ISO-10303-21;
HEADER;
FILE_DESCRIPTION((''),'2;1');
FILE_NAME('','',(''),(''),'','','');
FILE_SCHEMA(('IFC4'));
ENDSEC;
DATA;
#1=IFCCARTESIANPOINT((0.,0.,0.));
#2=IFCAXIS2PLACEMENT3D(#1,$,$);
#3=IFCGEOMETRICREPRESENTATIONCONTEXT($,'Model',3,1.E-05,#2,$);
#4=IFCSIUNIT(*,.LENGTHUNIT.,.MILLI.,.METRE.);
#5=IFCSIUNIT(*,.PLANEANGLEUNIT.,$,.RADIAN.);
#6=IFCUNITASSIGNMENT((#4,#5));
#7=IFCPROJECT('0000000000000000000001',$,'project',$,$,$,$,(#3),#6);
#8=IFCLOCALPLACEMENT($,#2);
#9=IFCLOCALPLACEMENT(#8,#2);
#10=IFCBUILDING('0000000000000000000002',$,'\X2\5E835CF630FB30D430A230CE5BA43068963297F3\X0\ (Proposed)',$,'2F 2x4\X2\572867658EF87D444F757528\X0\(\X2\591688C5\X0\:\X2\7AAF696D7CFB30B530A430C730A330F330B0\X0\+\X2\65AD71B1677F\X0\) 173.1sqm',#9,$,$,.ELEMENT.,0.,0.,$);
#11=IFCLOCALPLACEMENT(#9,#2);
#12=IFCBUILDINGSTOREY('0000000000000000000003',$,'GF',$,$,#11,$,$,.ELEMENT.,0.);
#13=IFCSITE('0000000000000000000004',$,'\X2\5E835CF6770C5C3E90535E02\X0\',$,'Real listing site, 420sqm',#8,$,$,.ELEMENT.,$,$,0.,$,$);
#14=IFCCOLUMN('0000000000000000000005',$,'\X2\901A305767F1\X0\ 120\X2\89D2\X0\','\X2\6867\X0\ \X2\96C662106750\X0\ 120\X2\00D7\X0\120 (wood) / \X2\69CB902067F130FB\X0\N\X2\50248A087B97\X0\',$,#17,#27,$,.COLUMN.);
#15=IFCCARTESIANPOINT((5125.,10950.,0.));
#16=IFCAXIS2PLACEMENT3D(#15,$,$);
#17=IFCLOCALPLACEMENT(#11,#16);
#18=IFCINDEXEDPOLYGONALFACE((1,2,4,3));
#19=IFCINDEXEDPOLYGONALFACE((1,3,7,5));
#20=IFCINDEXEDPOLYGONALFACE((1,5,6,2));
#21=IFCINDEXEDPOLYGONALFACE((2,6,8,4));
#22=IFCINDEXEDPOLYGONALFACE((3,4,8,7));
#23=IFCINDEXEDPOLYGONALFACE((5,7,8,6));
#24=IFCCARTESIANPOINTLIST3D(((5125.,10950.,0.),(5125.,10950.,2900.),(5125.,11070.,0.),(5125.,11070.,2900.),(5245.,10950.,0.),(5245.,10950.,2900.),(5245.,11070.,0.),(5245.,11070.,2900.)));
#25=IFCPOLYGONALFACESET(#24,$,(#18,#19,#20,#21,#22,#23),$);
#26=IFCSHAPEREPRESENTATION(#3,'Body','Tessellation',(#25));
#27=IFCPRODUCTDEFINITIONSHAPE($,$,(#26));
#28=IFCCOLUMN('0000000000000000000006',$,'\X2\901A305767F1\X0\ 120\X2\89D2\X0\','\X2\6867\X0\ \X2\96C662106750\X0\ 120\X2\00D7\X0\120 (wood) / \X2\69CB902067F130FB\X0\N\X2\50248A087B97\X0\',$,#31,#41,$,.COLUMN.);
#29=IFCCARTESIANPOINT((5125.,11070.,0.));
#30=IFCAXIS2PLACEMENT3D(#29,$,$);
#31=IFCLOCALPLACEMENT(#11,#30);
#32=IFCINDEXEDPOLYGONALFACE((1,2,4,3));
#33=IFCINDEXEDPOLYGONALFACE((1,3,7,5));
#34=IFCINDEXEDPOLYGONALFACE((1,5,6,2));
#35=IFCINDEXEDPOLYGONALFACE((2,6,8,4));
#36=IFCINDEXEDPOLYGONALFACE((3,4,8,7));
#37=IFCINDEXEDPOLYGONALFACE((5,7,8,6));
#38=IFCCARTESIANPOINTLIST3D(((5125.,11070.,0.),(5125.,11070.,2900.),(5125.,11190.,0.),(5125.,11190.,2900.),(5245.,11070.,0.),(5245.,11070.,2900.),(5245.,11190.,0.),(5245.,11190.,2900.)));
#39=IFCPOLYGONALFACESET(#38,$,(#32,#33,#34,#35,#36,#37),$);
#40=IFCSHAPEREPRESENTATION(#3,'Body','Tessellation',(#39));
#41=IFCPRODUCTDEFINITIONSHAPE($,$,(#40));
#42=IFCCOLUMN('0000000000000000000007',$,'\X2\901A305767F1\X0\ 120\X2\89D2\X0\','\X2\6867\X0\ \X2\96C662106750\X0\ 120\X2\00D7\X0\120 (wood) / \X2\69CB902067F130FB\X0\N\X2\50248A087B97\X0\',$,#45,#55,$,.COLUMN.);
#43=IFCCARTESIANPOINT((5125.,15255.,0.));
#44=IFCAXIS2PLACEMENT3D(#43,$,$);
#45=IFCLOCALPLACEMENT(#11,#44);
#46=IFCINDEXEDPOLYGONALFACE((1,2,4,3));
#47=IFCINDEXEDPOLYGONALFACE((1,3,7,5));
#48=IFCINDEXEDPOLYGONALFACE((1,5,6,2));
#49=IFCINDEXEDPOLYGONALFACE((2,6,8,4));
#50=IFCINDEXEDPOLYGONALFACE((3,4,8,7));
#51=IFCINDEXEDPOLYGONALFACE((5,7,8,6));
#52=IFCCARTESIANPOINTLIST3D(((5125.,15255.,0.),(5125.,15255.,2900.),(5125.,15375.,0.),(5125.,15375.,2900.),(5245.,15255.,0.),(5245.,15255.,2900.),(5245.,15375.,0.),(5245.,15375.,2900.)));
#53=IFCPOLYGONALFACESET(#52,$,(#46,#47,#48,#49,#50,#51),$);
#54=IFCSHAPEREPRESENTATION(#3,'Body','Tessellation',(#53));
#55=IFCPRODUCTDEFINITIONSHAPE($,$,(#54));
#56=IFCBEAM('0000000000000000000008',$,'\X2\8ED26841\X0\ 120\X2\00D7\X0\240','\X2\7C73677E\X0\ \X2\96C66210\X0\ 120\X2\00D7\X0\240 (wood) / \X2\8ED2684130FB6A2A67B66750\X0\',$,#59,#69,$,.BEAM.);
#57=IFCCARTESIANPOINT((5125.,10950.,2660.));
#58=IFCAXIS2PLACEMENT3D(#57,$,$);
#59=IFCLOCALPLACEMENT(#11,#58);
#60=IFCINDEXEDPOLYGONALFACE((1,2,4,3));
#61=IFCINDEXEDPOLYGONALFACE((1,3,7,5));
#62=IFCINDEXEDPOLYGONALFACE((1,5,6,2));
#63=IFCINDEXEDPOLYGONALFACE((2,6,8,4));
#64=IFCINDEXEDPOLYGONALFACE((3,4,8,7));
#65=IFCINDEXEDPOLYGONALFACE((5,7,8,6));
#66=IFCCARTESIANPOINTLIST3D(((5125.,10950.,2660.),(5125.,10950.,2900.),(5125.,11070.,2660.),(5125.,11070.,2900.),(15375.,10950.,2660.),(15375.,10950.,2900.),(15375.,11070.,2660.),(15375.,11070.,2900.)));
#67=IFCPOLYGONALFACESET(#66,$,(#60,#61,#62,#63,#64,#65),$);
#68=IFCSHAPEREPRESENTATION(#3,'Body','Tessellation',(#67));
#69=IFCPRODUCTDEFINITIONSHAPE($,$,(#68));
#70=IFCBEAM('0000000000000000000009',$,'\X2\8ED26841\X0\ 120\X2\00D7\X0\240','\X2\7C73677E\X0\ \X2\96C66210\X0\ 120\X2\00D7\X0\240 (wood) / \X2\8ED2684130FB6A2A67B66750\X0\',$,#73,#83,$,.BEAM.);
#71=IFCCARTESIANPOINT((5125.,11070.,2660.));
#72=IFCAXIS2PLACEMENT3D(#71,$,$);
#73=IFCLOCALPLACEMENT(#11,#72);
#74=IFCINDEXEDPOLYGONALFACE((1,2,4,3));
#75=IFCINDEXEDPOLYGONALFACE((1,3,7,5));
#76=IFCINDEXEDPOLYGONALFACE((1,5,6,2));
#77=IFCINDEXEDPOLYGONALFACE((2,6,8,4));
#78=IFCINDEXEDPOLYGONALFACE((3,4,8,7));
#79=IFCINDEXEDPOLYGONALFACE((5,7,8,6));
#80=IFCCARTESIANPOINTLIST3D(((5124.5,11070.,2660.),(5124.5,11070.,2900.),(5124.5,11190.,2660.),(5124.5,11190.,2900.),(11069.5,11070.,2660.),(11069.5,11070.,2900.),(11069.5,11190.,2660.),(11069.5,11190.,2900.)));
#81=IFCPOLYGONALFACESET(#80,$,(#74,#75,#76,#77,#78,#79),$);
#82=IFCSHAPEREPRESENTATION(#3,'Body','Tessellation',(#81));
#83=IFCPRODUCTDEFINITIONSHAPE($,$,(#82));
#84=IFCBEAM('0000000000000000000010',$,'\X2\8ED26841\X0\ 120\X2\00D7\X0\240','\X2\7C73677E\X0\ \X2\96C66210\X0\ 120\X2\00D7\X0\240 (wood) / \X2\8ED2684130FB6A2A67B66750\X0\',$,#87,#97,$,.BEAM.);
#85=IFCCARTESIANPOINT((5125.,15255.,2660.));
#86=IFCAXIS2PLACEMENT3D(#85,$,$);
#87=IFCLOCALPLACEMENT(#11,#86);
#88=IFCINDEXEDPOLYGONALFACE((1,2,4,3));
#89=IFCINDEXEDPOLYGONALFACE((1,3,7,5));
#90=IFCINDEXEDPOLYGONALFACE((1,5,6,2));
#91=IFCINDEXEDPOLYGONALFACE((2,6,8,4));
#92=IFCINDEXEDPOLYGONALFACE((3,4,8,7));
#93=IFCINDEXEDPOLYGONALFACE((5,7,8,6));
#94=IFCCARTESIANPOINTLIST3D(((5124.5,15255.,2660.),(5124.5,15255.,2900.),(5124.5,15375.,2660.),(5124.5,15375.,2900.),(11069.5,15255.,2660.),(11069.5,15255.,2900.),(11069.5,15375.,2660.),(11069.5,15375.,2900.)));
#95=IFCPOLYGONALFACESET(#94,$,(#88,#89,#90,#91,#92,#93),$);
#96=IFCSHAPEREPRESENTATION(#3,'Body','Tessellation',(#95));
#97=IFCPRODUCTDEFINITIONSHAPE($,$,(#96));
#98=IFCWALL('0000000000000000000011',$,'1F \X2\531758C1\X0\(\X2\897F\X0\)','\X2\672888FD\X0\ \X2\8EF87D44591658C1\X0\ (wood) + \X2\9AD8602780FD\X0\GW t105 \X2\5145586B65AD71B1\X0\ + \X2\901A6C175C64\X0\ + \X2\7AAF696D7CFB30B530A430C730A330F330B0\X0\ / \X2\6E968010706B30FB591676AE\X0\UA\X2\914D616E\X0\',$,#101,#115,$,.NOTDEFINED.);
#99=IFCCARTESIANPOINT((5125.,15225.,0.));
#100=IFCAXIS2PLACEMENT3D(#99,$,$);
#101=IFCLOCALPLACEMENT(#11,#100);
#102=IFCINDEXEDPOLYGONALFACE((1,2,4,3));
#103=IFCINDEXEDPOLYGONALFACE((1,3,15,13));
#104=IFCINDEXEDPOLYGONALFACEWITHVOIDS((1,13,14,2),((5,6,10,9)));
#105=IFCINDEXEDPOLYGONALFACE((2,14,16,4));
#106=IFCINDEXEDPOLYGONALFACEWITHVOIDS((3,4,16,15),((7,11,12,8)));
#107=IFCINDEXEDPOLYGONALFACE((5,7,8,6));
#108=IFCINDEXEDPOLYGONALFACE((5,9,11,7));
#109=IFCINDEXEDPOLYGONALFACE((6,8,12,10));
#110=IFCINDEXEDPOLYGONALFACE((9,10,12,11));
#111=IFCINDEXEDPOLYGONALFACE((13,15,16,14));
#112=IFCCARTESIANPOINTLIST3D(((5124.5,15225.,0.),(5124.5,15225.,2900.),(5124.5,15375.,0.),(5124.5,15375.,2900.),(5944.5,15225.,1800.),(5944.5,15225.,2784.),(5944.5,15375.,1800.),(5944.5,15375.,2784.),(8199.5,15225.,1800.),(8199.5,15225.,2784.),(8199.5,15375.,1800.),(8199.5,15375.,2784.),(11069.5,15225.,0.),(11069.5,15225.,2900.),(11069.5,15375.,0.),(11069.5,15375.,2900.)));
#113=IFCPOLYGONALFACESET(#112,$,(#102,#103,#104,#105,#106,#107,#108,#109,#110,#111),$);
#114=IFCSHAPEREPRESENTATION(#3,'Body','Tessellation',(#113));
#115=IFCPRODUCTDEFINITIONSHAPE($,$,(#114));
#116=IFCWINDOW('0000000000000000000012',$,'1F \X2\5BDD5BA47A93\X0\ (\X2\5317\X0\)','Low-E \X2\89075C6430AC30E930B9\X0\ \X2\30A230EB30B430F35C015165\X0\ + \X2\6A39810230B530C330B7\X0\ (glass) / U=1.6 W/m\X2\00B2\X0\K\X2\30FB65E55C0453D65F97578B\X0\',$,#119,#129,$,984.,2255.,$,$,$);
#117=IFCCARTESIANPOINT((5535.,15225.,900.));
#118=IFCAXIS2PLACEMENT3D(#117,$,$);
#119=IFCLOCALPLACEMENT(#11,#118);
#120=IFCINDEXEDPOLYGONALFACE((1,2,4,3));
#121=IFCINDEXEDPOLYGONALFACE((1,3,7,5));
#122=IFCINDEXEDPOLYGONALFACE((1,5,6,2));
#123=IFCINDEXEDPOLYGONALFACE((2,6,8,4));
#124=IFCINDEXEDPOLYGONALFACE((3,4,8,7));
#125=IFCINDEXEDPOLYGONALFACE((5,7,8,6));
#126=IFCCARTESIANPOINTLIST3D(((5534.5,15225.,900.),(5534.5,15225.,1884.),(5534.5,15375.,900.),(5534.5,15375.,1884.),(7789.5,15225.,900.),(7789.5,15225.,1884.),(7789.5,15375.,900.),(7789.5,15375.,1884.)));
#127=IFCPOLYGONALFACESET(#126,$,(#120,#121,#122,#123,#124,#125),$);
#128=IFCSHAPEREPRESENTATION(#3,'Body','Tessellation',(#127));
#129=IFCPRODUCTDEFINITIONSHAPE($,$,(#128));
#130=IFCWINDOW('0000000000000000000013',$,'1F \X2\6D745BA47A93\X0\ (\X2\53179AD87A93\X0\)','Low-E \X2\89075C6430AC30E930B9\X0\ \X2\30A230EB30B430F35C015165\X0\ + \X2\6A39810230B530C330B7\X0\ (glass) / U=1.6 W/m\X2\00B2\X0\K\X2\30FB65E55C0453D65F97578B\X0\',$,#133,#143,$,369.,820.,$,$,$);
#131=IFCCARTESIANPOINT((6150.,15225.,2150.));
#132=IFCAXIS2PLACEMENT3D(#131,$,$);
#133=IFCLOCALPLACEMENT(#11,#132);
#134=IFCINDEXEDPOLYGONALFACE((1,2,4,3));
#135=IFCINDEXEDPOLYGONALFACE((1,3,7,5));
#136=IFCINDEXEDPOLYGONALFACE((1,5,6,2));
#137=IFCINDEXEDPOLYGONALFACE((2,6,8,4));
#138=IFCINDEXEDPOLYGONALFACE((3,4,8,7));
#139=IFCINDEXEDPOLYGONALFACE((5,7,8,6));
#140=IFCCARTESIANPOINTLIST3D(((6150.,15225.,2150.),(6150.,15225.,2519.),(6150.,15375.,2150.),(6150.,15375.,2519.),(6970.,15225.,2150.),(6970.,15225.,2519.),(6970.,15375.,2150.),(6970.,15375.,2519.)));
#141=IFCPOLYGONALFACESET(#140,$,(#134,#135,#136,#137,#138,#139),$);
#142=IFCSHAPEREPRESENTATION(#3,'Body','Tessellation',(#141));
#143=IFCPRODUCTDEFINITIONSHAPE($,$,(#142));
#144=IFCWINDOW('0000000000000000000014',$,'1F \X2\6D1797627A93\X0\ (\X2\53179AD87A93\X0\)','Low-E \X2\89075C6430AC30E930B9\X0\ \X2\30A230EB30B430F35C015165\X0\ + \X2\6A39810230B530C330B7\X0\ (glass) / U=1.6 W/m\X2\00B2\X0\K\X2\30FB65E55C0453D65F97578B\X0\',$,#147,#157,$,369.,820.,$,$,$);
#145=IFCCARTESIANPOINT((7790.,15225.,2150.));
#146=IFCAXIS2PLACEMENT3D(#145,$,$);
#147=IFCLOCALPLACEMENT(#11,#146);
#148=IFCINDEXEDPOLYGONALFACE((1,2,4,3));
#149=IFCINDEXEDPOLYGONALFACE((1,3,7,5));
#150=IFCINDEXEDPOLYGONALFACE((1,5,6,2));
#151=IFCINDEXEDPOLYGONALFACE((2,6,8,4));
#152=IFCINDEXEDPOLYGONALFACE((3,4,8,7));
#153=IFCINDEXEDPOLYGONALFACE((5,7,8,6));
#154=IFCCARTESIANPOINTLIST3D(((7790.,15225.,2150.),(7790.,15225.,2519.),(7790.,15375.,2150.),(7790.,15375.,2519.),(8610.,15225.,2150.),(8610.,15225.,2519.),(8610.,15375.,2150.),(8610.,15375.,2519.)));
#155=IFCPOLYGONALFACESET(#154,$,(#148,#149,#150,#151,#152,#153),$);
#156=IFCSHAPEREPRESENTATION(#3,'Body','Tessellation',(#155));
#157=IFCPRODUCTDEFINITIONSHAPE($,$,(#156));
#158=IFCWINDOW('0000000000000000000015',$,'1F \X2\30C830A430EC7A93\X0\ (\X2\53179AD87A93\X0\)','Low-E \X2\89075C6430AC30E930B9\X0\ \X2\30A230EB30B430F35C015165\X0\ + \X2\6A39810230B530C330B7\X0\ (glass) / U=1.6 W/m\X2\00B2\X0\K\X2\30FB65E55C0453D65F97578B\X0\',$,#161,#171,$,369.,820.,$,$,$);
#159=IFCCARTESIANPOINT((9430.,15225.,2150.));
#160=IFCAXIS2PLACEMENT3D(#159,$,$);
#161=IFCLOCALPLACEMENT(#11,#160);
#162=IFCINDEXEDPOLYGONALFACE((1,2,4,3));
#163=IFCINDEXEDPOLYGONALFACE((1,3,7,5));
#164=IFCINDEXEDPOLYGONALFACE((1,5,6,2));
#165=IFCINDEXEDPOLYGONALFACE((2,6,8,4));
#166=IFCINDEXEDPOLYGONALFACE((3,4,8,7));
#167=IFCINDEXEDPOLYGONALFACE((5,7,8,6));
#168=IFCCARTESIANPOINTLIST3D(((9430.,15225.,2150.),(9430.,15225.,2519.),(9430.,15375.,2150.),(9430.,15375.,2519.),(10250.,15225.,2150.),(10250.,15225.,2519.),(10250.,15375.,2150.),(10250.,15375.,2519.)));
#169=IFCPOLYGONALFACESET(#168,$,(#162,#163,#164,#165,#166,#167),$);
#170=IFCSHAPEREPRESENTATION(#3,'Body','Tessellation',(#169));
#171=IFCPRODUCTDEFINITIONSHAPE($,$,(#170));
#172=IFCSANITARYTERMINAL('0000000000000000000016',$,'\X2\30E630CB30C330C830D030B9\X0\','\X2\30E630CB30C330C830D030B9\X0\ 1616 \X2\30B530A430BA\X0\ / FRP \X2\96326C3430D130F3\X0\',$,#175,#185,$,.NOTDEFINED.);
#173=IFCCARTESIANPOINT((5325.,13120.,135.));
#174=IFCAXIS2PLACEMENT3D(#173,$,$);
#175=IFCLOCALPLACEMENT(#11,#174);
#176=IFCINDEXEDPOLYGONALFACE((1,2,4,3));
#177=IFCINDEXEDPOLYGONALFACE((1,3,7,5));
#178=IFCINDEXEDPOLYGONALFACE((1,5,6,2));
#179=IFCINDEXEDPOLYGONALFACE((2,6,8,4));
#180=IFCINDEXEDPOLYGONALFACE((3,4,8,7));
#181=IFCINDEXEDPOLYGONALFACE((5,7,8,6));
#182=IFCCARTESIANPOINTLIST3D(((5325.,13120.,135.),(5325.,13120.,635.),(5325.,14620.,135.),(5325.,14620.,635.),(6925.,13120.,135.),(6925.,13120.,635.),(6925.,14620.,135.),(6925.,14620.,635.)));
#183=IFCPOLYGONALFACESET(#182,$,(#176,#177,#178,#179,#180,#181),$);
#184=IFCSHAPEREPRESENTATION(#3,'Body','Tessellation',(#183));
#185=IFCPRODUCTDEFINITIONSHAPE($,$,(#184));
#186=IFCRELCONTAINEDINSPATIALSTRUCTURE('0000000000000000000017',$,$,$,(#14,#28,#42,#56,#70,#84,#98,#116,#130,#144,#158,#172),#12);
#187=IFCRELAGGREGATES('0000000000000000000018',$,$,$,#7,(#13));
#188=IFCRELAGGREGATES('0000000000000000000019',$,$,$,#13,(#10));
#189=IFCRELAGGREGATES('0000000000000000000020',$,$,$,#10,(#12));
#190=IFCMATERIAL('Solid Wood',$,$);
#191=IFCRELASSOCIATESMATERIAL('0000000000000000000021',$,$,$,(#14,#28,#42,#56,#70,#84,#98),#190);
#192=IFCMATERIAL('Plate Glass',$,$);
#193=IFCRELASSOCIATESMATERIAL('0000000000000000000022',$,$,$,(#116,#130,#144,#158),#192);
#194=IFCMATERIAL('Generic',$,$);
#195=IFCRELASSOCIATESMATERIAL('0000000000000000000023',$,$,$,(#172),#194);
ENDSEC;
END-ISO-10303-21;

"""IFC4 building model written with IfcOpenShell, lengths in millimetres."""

from ifc_helpers import new_model, si_unit, frame, frame_2d, origin, place, context, project, spatial, rectangle, extrude, material, element, fill, save


model = new_model("IFC4")

# Units and contexts
model_context = context("Model", 3, precision=1e-05, world=origin())
ifc_project = project(units=[si_unit("LENGTHUNIT", "METRE", prefix="MILLI"), si_unit("PLANEANGLEUNIT", "RADIAN")], contexts=[model_context])

# Site, building, storey
site_placement = place(None, origin())
site = spatial("IfcSite", under=ifc_project, at=site_placement, Name="広島県尾道市", ObjectType="Real listing site, 420sqm", CompositionType="ELEMENT", RefElevation=0.0)
building_placement = place(site_placement, origin())
building = spatial("IfcBuilding", under=site, at=building_placement, Name="広島・ピアノ室と防音 (Proposed)", ObjectType="2F 2x4在来軸組併用(外装:窯業系サイディング+断熱板) 173.1sqm", CompositionType="ELEMENT", ElevationOfRefHeight=0.0, ElevationOfTerrain=0.0)
storey_placement = place(building_placement, origin())
storey = spatial("IfcBuildingStorey", under=building, at=storey_placement, Name="GF", CompositionType="ELEMENT", Elevation=0.0)

# Columns
ifc_material_1 = material(Name="Solid Wood")
column_1_placement = place(storey_placement, frame((5125.0, 10950.0, 0.0)))
element("IfcColumn", 1, at=column_1_placement, inside=storey, material=ifc_material_1, Name="通し柱 120角", Description="桧 集成材 120×120 (wood) / 構造柱・N値計算", PredefinedType="COLUMN", context=model_context, shape_type="SweptSolid", body=[
    extrude(rectangle(XDim=120.0, YDim=120.0, at=frame_2d((60.0, 60.0))), frame((5125.0, 10950.0, 0.0)), (0.0, 0.0, 1.0), 2900.0),
])
column_2_placement = place(storey_placement, frame((5125.0, 11070.0, 0.0)))
element("IfcColumn", 2, at=column_2_placement, inside=storey, material=ifc_material_1, Name="通し柱 120角", Description="桧 集成材 120×120 (wood) / 構造柱・N値計算", PredefinedType="COLUMN", context=model_context, shape_type="SweptSolid", body=[
    extrude(rectangle(XDim=120.0, YDim=120.0, at=frame_2d((60.0, 60.0))), frame((5125.0, 11070.0, 0.0)), (0.0, 0.0, 1.0), 2900.0),
])
column_3_placement = place(storey_placement, frame((5125.0, 15255.0, 0.0)))
element("IfcColumn", 3, at=column_3_placement, inside=storey, material=ifc_material_1, Name="通し柱 120角", Description="桧 集成材 120×120 (wood) / 構造柱・N値計算", PredefinedType="COLUMN", context=model_context, shape_type="SweptSolid", body=[
    extrude(rectangle(XDim=120.0, YDim=120.0, at=frame_2d((60.0, 60.0))), frame((5125.0, 15255.0, 0.0)), (0.0, 0.0, 1.0), 2900.0),
])

# Beams
beam_1_placement = place(storey_placement, frame((5125.0, 10950.0, 2660.0)))
element("IfcBeam", 4, at=beam_1_placement, inside=storey, material=ifc_material_1, Name="軒桁 120×240", Description="米松 集成 120×240 (wood) / 軒桁・横架材", PredefinedType="BEAM", context=model_context, shape_type="SweptSolid", body=[
    extrude(rectangle(XDim=10250.0, YDim=120.0, at=frame_2d((5125.0, 60.0))), frame((5125.0, 10950.0, 2660.0)), (0.0, 0.0, 1.0), 240.0),
])
beam_2_placement = place(storey_placement, frame((5125.0, 11070.0, 2660.0)))
element("IfcBeam", 5, at=beam_2_placement, inside=storey, material=ifc_material_1, Name="軒桁 120×240", Description="米松 集成 120×240 (wood) / 軒桁・横架材", PredefinedType="BEAM", context=model_context, shape_type="SweptSolid", body=[
    extrude(rectangle(XDim=5945.0, YDim=120.0, at=frame_2d((2972.0, 60.0))), frame((5125.0, 11070.0, 2660.0)), (0.0, 0.0, 1.0), 240.0),
])
beam_3_placement = place(storey_placement, frame((5125.0, 15255.0, 2660.0)))
element("IfcBeam", 6, at=beam_3_placement, inside=storey, material=ifc_material_1, Name="軒桁 120×240", Description="米松 集成 120×240 (wood) / 軒桁・横架材", PredefinedType="BEAM", context=model_context, shape_type="SweptSolid", body=[
    extrude(rectangle(XDim=5945.0, YDim=120.0, at=frame_2d((2972.0, 60.0))), frame((5125.0, 15255.0, 2660.0)), (0.0, 0.0, 1.0), 240.0),
])

# Wall, openings, windows
wall_1_placement = place(storey_placement, frame((5125.0, 15225.0, 0.0)))
wall_1 = element("IfcWall", 7, at=wall_1_placement, inside=storey, material=ifc_material_1, Name="1F 北壁(西)", Description="木製 軸組外壁 (wood) + 高性能GW t105 充填断熱 + 通気層 + 窯業系サイディング / 準耐火・外皮UA配慮", PredefinedType="NOTDEFINED", context=model_context, shape_type="SweptSolid", body=[
    extrude(rectangle(XDim=5945.0, YDim=150.0, at=frame_2d((2972.0, 75.0))), frame((5125.0, 15225.0, 0.0)), (0.0, 0.0, 1.0), 2900.0),
])
opening_1_placement = place(storey_placement, frame((5535.0, 15225.0, 900.0)))
opening_1 = element("IfcOpeningElement", 8, at=opening_1_placement, cuts=wall_1, PredefinedType="NOTDEFINED", context=model_context, shape_type="SweptSolid", body=[
    extrude(rectangle(XDim=2255.0, YDim=150.0, at=frame_2d((1127.0, 75.0))), frame((5535.0, 15225.0, 900.0)), (0.0, 0.0, 1.0), 984.0),
])
opening_2_placement = place(storey_placement, frame((6150.0, 15225.0, 2150.0)))
opening_2 = element("IfcOpeningElement", 9, at=opening_2_placement, cuts=wall_1, PredefinedType="NOTDEFINED", context=model_context, shape_type="SweptSolid", body=[
    extrude(rectangle(XDim=820.0, YDim=150.0, at=frame_2d((410.0, 75.0))), frame((6150.0, 15225.0, 2150.0)), (0.0, 0.0, 1.0), 369.0),
])
opening_3_placement = place(storey_placement, frame((7790.0, 15225.0, 2150.0)))
opening_3 = element("IfcOpeningElement", 10, at=opening_3_placement, cuts=wall_1, PredefinedType="NOTDEFINED", context=model_context, shape_type="SweptSolid", body=[
    extrude(rectangle(XDim=820.0, YDim=150.0, at=frame_2d((410.0, 75.0))), frame((7790.0, 15225.0, 2150.0)), (0.0, 0.0, 1.0), 369.0),
])
opening_4_placement = place(storey_placement, frame((9430.0, 15225.0, 2150.0)))
opening_4 = element("IfcOpeningElement", 11, at=opening_4_placement, cuts=wall_1, PredefinedType="NOTDEFINED", context=model_context, shape_type="SweptSolid", body=[
    extrude(rectangle(XDim=820.0, YDim=150.0, at=frame_2d((410.0, 75.0))), frame((9430.0, 15225.0, 2150.0)), (0.0, 0.0, 1.0), 369.0),
])
ifc_material_2 = material(Name="Plate Glass")
window_1_placement = place(storey_placement, frame((5535.0, 15225.0, 900.0)))
window_1 = element("IfcWindow", 12, at=window_1_placement, inside=storey, material=ifc_material_2, Name="1F 寝室窓 (北)", Description="Low-E 複層ガラス アルゴン封入 + 樹脂サッシ (glass) / U=1.6 W/m²K・日射取得型", OverallHeight=984.0, OverallWidth=2255.0, context=model_context, shape_type="SweptSolid", body=[
    extrude(rectangle(XDim=2255.0, YDim=150.0, at=frame_2d((1127.0, 75.0))), frame((5535.0, 15225.0, 900.0)), (0.0, 0.0, 1.0), 984.0),
])
fill(opening_1, window_1)
window_2_placement = place(storey_placement, frame((6150.0, 15225.0, 2150.0)))
window_2 = element("IfcWindow", 13, at=window_2_placement, inside=storey, material=ifc_material_2, Name="1F 浴室窓 (北高窓)", Description="Low-E 複層ガラス アルゴン封入 + 樹脂サッシ (glass) / U=1.6 W/m²K・日射取得型", OverallHeight=369.0, OverallWidth=820.0, context=model_context, shape_type="SweptSolid", body=[
    extrude(rectangle(XDim=820.0, YDim=150.0, at=frame_2d((410.0, 75.0))), frame((6150.0, 15225.0, 2150.0)), (0.0, 0.0, 1.0), 369.0),
])
fill(opening_2, window_2)
window_3_placement = place(storey_placement, frame((7790.0, 15225.0, 2150.0)))
window_3 = element("IfcWindow", 14, at=window_3_placement, inside=storey, material=ifc_material_2, Name="1F 洗面窓 (北高窓)", Description="Low-E 複層ガラス アルゴン封入 + 樹脂サッシ (glass) / U=1.6 W/m²K・日射取得型", OverallHeight=369.0, OverallWidth=820.0, context=model_context, shape_type="SweptSolid", body=[
    extrude(rectangle(XDim=820.0, YDim=150.0, at=frame_2d((410.0, 75.0))), frame((7790.0, 15225.0, 2150.0)), (0.0, 0.0, 1.0), 369.0),
])
fill(opening_3, window_3)
window_4_placement = place(storey_placement, frame((9430.0, 15225.0, 2150.0)))
window_4 = element("IfcWindow", 15, at=window_4_placement, inside=storey, material=ifc_material_2, Name="1F トイレ窓 (北高窓)", Description="Low-E 複層ガラス アルゴン封入 + 樹脂サッシ (glass) / U=1.6 W/m²K・日射取得型", OverallHeight=369.0, OverallWidth=820.0, context=model_context, shape_type="SweptSolid", body=[
    extrude(rectangle(XDim=820.0, YDim=150.0, at=frame_2d((410.0, 75.0))), frame((9430.0, 15225.0, 2150.0)), (0.0, 0.0, 1.0), 369.0),
])
fill(opening_4, window_4)

# Shared definitions
ifc_material_3 = material(Name="Generic")

# Sanitary terminal
sanitary_terminal_placement = place(storey_placement, frame((5325.0, 13120.0, 135.0)))
element("IfcSanitaryTerminal", 16, at=sanitary_terminal_placement, inside=storey, material=ifc_material_3, Name="ユニットバス", Description="ユニットバス 1616 サイズ / FRP 防水パン", PredefinedType="NOTDEFINED", context=model_context, shape_type="SweptSolid", body=[
    extrude(rectangle(XDim=1600.0, YDim=1500.0, at=frame_2d((800.0, 750.0))), frame((5325.0, 13120.0, 135.0)), (0.0, 0.0, 1.0), 500.0),
])

save(model, "model.ifc")
